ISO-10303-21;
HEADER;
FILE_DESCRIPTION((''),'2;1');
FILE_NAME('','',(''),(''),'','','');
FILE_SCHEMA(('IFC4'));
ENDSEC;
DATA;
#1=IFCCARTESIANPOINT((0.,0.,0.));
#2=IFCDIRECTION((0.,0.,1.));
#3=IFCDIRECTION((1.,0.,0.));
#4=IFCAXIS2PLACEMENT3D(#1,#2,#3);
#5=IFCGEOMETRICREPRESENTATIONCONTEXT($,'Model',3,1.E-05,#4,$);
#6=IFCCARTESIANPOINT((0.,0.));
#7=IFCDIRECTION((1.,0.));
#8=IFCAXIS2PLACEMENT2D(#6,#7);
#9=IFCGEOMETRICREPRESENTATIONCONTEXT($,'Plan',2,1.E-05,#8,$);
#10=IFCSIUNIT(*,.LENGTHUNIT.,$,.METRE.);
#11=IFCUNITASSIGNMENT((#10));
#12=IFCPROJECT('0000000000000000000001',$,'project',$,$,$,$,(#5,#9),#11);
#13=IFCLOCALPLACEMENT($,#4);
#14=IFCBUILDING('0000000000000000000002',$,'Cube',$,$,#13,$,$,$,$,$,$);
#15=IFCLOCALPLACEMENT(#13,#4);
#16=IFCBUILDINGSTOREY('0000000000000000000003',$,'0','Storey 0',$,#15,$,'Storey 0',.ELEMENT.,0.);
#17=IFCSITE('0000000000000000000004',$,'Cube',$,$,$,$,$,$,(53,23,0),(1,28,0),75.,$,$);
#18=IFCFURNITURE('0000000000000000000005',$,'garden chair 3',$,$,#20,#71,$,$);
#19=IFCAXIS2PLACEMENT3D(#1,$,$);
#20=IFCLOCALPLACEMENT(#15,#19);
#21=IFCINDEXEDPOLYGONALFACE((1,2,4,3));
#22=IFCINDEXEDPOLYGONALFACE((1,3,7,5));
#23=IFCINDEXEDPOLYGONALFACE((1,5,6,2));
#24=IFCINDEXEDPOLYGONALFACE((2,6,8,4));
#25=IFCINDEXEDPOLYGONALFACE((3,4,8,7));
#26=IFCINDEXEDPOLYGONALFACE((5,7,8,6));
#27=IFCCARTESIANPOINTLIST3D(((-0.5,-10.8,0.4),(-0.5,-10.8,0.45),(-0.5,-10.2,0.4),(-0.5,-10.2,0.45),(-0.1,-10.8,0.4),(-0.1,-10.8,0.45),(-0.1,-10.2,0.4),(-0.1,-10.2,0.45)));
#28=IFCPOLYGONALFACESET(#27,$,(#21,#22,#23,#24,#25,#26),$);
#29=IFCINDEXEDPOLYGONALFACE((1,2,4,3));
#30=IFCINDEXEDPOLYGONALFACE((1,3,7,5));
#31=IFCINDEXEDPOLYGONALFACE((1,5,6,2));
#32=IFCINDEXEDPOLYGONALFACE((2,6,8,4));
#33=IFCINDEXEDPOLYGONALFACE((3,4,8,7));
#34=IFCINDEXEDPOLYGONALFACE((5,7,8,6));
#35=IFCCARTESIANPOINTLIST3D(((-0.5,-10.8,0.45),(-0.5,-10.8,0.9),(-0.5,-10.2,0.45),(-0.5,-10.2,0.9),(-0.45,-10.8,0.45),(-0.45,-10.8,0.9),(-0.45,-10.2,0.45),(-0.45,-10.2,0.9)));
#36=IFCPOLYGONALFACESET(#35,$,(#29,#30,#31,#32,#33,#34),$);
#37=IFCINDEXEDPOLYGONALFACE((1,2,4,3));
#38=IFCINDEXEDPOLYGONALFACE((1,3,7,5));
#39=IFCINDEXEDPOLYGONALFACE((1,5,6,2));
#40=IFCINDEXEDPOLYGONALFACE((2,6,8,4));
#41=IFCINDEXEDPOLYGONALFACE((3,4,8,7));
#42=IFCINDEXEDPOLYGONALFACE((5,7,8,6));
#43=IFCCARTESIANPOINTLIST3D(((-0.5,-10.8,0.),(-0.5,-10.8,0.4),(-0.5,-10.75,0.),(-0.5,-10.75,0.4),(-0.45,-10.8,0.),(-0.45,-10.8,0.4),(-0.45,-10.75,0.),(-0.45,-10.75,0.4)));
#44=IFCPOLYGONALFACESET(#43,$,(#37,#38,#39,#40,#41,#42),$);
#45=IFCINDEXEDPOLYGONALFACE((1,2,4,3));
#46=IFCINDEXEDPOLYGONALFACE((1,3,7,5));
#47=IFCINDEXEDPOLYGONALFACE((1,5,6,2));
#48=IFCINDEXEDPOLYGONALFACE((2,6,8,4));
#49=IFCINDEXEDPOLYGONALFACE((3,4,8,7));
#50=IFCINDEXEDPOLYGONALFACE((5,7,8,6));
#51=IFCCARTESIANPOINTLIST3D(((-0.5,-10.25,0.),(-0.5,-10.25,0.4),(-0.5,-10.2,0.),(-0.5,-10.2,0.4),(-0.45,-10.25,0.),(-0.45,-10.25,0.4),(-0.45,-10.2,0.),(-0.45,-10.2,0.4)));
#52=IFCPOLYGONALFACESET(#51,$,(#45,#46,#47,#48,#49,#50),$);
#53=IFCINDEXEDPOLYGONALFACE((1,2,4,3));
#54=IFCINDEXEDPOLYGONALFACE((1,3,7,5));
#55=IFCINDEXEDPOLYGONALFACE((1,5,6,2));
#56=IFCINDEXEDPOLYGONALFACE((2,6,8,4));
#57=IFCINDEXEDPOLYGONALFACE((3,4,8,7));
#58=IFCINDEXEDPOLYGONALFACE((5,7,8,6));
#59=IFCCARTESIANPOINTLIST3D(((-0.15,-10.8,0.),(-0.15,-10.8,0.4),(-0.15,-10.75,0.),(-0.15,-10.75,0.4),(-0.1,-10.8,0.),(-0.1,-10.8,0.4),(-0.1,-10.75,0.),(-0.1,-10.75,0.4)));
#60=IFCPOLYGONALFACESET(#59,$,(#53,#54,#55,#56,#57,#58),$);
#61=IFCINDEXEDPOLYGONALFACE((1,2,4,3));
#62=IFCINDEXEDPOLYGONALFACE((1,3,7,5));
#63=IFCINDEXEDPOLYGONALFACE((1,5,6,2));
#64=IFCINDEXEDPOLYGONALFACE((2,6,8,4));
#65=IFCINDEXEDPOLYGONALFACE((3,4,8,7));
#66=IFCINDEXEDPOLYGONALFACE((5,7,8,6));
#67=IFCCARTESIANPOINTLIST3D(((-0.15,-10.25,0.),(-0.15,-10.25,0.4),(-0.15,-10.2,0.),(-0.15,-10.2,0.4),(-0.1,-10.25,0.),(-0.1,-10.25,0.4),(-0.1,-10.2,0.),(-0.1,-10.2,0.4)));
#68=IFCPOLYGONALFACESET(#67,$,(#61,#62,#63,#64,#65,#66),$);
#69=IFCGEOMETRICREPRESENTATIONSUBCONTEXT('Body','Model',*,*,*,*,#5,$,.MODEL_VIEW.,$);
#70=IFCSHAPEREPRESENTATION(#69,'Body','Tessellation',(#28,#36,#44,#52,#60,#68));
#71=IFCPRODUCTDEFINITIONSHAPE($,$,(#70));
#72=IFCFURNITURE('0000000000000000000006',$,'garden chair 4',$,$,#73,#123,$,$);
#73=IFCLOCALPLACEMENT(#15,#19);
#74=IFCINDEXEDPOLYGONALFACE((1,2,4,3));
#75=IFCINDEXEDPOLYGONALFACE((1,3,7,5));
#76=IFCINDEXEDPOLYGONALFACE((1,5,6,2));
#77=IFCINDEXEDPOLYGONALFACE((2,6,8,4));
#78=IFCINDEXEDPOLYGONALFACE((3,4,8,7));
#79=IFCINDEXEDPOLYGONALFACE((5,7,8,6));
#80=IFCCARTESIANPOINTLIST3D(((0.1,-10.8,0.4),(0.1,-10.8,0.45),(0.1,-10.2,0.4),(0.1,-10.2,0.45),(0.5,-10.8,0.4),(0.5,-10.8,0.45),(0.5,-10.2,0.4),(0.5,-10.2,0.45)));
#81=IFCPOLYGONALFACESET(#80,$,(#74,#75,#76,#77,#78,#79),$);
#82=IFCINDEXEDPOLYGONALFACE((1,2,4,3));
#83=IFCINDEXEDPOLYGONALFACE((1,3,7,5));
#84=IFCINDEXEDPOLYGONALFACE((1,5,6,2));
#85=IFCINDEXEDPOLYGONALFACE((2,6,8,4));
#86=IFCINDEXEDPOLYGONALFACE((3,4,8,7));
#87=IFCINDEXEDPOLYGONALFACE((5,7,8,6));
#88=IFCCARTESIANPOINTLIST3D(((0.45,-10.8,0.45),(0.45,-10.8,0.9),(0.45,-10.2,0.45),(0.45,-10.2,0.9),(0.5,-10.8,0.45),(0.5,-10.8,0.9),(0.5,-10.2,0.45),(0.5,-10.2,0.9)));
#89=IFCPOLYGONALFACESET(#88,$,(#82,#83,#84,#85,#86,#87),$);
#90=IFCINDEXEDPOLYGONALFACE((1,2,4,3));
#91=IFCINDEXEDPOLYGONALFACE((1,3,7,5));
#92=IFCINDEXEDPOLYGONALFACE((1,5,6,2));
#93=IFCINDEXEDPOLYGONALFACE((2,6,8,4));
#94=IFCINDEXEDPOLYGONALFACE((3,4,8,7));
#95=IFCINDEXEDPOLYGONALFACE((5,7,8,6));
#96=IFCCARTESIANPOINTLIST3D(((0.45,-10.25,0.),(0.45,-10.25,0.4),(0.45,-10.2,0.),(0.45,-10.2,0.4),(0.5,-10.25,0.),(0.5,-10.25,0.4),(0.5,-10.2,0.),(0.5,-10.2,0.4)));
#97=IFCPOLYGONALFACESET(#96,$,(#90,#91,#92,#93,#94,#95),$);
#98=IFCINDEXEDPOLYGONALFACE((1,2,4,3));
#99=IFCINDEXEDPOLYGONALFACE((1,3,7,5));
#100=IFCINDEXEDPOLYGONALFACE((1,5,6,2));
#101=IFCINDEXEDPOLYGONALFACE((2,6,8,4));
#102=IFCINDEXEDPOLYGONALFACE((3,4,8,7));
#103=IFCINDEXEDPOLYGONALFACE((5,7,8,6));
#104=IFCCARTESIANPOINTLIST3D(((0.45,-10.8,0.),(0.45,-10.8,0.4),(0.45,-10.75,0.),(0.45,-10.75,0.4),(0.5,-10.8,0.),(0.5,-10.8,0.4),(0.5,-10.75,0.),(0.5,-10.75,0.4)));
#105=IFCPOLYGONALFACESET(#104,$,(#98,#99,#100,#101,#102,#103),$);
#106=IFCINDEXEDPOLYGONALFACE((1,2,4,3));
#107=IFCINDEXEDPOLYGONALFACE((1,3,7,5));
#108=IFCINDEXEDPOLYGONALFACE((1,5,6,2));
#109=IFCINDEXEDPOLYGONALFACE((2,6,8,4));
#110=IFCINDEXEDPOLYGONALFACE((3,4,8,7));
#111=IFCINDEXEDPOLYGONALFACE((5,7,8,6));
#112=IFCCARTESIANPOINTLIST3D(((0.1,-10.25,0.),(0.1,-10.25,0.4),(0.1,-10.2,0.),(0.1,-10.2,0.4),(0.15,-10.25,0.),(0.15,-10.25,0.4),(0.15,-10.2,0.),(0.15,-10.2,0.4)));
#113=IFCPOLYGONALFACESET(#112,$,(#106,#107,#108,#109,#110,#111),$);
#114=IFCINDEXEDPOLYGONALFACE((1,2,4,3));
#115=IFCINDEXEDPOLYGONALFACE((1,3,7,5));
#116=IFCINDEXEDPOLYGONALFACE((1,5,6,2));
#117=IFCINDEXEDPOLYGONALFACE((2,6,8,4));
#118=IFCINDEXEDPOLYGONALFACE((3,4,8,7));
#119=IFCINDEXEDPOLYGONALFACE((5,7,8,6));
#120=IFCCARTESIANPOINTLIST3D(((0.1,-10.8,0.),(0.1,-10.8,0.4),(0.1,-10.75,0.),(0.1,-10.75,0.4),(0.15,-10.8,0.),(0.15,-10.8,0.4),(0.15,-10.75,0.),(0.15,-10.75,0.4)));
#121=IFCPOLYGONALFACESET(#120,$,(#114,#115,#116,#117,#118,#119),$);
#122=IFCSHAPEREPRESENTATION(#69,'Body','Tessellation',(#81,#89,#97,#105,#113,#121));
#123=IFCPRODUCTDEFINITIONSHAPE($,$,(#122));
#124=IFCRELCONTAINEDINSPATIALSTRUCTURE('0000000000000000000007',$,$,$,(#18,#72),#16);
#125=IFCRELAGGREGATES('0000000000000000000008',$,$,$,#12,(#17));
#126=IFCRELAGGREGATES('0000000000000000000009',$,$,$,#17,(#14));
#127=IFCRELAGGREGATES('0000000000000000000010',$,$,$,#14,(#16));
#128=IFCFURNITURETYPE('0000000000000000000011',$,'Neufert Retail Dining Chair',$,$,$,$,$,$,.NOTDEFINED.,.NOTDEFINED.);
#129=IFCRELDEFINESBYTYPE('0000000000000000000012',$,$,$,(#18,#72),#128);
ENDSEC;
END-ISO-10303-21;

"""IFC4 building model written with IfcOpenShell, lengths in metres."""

from ifc_helpers import new_model, entity, si_unit, frame, origin_with_axes, origin_2d_with_axis, place, context, subcontext, project, spatial, line, indexed_curve, outline, extrude, shape, source, transform, mapped, type_object, type_shapes, element, save


model = new_model("IFC4")

# Units and contexts
model_context = context("Model", 3, precision=1e-05, world=origin_with_axes())
plan_context = context("Plan", 2, precision=1e-05, world=origin_2d_with_axis())
body_context_1 = subcontext(model_context, "Body", "Model", "MODEL_VIEW")
body_context_2 = subcontext(plan_context, "Body", "Plan", "PLAN_VIEW")
ifc_project = project(units=[si_unit("LENGTHUNIT", "METRE")], contexts=[model_context, plan_context])

# Site, building, storey
site = spatial("IfcSite", under=ifc_project, Name="Cube", RefLatitude=(53, 23, 0), RefLongitude=(1, 28, 0), RefElevation=75.0)
building_placement = place(None, origin_with_axes())
building = spatial("IfcBuilding", under=site, at=building_placement, Name="Cube")
storey_placement = place(building_placement, origin_with_axes())
storey = spatial("IfcBuildingStorey", under=building, at=storey_placement, Name="0", Description="Storey 0", LongName="Storey 0", CompositionType="ELEMENT", Elevation=0.0)

# Furniture
furniture_type_1 = type_object("IfcFurnitureType", Name="Neufert Retail Dining Chair", AssemblyPlace="NOTDEFINED", PredefinedType="NOTDEFINED")
shared_shape_1 = source(origin_with_axes(), body_context_1, "Body", "SweptSolid", [
    extrude(outline(indexed_curve([(-0.3, 0.0), (0.3, 0.0), (0.3, -0.4), (-0.3, -0.4)], segments=[line(1, 2, 3, 4, 1)])), frame((0.0, 0.0, 0.45), z_axis=(0.0, 0.0, 1.0), x_axis=(1.0, 0.0, 0.0)), (0.0, 0.0, -1.0), 0.05),
    extrude(outline(indexed_curve([(-0.3, 0.0), (0.3, 0.0), (0.3, -0.05), (-0.3, -0.05)], segments=[line(1, 2, 3, 4, 1)])), frame((0.0, 0.0, 0.9), z_axis=(0.0, 0.0, 1.0), x_axis=(1.0, 0.0, 0.0)), (0.0, 0.0, -1.0), 0.45),
    extrude(outline(indexed_curve([(-0.3, 0.0), (-0.25, 0.0), (-0.25, -0.05), (-0.3, -0.05)], segments=[line(1, 2, 3, 4, 1)])), origin_with_axes(), (0.0, 0.0, 1.0), 0.4),
    extrude(outline(indexed_curve([(0.3, 0.0), (0.25, 0.0), (0.25, -0.05), (0.3, -0.05)], segments=[line(1, 2, 3, 4, 1)])), origin_with_axes(), (0.0, 0.0, 1.0), 0.4),
    extrude(outline(indexed_curve([(-0.3, -0.4), (-0.25, -0.4), (-0.25, -0.35), (-0.3, -0.35)], segments=[line(1, 2, 3, 4, 1)])), origin_with_axes(), (0.0, 0.0, 1.0), 0.4),
    extrude(outline(indexed_curve([(0.3, -0.4), (0.25, -0.4), (0.25, -0.35), (0.3, -0.35)], segments=[line(1, 2, 3, 4, 1)])), origin_with_axes(), (0.0, 0.0, 1.0), 0.4),
])
shared_shape_2 = source(origin_with_axes(), body_context_2, "Body", "Curve2D", [
    entity("IfcIndexedPolyCurve", entity("IfcCartesianPointList2D", [[-0.3, -0.4], [0.3, -0.4]])),
    entity("IfcIndexedPolyCurve", entity("IfcCartesianPointList2D", [[-0.3, -0.4], [-0.3, -0.3], [-0.2121, -0.0879], [0.0, 0.0], [0.2121, -0.0879], [0.3, -0.3], [0.3, -0.4]]), [entity("IfcLineIndex", [1, 2]), entity("IfcArcIndex", [2, 3, 4]), entity("IfcArcIndex", [4, 5, 6]), entity("IfcLineIndex", [6, 7])]),
    entity("IfcIndexedPolyCurve", entity("IfcCartesianPointList2D", [[-0.26, -0.4], [-0.26, -0.3], [-0.1838, -0.1162], [0.0, -0.04], [0.1838, -0.1162], [0.26, -0.3], [0.26, -0.4]]), [entity("IfcLineIndex", [1, 2]), entity("IfcArcIndex", [2, 3, 4]), entity("IfcArcIndex", [4, 5, 6]), entity("IfcLineIndex", [6, 7])]),
])
type_shapes(furniture_type_1, [shared_shape_1, shared_shape_2])
for number, where, z_axis, x_axis, name in (
    (1, (-0.5, -10.5, 0.0), (0.0, 0.0, 1.0), (0.0, 1.0, 0.0), "garden chair 3"),
    (2, (0.5, -10.5, 0.0), (0.0, 0.0, 1.0), (0.0, -1.0, 0.0), "garden chair 4"),
):
    element("IfcFurniture", number, at=place(storey_placement, frame(where, z_axis=z_axis, x_axis=x_axis)), inside=storey, type_object=furniture_type_1, Name=name, shapes=[
        shape(body_context_1, "Body", "MappedRepresentation", [mapped(shared_shape_1, transform((0.0, 0.0, 0.0), x_axis=(1.0, 0.0, 0.0), y_axis=(0.0, 1.0, 0.0), z_axis=(0.0, 0.0, 1.0), scale=1.0))]),
        shape(body_context_2, "Body", "MappedRepresentation", [mapped(shared_shape_2, transform((0.0, 0.0, 0.0), x_axis=(1.0, 0.0, 0.0), y_axis=(0.0, 1.0, 0.0), z_axis=(0.0, 0.0, 1.0), scale=1.0))]),
    ])

save(model, "model.ifc")
